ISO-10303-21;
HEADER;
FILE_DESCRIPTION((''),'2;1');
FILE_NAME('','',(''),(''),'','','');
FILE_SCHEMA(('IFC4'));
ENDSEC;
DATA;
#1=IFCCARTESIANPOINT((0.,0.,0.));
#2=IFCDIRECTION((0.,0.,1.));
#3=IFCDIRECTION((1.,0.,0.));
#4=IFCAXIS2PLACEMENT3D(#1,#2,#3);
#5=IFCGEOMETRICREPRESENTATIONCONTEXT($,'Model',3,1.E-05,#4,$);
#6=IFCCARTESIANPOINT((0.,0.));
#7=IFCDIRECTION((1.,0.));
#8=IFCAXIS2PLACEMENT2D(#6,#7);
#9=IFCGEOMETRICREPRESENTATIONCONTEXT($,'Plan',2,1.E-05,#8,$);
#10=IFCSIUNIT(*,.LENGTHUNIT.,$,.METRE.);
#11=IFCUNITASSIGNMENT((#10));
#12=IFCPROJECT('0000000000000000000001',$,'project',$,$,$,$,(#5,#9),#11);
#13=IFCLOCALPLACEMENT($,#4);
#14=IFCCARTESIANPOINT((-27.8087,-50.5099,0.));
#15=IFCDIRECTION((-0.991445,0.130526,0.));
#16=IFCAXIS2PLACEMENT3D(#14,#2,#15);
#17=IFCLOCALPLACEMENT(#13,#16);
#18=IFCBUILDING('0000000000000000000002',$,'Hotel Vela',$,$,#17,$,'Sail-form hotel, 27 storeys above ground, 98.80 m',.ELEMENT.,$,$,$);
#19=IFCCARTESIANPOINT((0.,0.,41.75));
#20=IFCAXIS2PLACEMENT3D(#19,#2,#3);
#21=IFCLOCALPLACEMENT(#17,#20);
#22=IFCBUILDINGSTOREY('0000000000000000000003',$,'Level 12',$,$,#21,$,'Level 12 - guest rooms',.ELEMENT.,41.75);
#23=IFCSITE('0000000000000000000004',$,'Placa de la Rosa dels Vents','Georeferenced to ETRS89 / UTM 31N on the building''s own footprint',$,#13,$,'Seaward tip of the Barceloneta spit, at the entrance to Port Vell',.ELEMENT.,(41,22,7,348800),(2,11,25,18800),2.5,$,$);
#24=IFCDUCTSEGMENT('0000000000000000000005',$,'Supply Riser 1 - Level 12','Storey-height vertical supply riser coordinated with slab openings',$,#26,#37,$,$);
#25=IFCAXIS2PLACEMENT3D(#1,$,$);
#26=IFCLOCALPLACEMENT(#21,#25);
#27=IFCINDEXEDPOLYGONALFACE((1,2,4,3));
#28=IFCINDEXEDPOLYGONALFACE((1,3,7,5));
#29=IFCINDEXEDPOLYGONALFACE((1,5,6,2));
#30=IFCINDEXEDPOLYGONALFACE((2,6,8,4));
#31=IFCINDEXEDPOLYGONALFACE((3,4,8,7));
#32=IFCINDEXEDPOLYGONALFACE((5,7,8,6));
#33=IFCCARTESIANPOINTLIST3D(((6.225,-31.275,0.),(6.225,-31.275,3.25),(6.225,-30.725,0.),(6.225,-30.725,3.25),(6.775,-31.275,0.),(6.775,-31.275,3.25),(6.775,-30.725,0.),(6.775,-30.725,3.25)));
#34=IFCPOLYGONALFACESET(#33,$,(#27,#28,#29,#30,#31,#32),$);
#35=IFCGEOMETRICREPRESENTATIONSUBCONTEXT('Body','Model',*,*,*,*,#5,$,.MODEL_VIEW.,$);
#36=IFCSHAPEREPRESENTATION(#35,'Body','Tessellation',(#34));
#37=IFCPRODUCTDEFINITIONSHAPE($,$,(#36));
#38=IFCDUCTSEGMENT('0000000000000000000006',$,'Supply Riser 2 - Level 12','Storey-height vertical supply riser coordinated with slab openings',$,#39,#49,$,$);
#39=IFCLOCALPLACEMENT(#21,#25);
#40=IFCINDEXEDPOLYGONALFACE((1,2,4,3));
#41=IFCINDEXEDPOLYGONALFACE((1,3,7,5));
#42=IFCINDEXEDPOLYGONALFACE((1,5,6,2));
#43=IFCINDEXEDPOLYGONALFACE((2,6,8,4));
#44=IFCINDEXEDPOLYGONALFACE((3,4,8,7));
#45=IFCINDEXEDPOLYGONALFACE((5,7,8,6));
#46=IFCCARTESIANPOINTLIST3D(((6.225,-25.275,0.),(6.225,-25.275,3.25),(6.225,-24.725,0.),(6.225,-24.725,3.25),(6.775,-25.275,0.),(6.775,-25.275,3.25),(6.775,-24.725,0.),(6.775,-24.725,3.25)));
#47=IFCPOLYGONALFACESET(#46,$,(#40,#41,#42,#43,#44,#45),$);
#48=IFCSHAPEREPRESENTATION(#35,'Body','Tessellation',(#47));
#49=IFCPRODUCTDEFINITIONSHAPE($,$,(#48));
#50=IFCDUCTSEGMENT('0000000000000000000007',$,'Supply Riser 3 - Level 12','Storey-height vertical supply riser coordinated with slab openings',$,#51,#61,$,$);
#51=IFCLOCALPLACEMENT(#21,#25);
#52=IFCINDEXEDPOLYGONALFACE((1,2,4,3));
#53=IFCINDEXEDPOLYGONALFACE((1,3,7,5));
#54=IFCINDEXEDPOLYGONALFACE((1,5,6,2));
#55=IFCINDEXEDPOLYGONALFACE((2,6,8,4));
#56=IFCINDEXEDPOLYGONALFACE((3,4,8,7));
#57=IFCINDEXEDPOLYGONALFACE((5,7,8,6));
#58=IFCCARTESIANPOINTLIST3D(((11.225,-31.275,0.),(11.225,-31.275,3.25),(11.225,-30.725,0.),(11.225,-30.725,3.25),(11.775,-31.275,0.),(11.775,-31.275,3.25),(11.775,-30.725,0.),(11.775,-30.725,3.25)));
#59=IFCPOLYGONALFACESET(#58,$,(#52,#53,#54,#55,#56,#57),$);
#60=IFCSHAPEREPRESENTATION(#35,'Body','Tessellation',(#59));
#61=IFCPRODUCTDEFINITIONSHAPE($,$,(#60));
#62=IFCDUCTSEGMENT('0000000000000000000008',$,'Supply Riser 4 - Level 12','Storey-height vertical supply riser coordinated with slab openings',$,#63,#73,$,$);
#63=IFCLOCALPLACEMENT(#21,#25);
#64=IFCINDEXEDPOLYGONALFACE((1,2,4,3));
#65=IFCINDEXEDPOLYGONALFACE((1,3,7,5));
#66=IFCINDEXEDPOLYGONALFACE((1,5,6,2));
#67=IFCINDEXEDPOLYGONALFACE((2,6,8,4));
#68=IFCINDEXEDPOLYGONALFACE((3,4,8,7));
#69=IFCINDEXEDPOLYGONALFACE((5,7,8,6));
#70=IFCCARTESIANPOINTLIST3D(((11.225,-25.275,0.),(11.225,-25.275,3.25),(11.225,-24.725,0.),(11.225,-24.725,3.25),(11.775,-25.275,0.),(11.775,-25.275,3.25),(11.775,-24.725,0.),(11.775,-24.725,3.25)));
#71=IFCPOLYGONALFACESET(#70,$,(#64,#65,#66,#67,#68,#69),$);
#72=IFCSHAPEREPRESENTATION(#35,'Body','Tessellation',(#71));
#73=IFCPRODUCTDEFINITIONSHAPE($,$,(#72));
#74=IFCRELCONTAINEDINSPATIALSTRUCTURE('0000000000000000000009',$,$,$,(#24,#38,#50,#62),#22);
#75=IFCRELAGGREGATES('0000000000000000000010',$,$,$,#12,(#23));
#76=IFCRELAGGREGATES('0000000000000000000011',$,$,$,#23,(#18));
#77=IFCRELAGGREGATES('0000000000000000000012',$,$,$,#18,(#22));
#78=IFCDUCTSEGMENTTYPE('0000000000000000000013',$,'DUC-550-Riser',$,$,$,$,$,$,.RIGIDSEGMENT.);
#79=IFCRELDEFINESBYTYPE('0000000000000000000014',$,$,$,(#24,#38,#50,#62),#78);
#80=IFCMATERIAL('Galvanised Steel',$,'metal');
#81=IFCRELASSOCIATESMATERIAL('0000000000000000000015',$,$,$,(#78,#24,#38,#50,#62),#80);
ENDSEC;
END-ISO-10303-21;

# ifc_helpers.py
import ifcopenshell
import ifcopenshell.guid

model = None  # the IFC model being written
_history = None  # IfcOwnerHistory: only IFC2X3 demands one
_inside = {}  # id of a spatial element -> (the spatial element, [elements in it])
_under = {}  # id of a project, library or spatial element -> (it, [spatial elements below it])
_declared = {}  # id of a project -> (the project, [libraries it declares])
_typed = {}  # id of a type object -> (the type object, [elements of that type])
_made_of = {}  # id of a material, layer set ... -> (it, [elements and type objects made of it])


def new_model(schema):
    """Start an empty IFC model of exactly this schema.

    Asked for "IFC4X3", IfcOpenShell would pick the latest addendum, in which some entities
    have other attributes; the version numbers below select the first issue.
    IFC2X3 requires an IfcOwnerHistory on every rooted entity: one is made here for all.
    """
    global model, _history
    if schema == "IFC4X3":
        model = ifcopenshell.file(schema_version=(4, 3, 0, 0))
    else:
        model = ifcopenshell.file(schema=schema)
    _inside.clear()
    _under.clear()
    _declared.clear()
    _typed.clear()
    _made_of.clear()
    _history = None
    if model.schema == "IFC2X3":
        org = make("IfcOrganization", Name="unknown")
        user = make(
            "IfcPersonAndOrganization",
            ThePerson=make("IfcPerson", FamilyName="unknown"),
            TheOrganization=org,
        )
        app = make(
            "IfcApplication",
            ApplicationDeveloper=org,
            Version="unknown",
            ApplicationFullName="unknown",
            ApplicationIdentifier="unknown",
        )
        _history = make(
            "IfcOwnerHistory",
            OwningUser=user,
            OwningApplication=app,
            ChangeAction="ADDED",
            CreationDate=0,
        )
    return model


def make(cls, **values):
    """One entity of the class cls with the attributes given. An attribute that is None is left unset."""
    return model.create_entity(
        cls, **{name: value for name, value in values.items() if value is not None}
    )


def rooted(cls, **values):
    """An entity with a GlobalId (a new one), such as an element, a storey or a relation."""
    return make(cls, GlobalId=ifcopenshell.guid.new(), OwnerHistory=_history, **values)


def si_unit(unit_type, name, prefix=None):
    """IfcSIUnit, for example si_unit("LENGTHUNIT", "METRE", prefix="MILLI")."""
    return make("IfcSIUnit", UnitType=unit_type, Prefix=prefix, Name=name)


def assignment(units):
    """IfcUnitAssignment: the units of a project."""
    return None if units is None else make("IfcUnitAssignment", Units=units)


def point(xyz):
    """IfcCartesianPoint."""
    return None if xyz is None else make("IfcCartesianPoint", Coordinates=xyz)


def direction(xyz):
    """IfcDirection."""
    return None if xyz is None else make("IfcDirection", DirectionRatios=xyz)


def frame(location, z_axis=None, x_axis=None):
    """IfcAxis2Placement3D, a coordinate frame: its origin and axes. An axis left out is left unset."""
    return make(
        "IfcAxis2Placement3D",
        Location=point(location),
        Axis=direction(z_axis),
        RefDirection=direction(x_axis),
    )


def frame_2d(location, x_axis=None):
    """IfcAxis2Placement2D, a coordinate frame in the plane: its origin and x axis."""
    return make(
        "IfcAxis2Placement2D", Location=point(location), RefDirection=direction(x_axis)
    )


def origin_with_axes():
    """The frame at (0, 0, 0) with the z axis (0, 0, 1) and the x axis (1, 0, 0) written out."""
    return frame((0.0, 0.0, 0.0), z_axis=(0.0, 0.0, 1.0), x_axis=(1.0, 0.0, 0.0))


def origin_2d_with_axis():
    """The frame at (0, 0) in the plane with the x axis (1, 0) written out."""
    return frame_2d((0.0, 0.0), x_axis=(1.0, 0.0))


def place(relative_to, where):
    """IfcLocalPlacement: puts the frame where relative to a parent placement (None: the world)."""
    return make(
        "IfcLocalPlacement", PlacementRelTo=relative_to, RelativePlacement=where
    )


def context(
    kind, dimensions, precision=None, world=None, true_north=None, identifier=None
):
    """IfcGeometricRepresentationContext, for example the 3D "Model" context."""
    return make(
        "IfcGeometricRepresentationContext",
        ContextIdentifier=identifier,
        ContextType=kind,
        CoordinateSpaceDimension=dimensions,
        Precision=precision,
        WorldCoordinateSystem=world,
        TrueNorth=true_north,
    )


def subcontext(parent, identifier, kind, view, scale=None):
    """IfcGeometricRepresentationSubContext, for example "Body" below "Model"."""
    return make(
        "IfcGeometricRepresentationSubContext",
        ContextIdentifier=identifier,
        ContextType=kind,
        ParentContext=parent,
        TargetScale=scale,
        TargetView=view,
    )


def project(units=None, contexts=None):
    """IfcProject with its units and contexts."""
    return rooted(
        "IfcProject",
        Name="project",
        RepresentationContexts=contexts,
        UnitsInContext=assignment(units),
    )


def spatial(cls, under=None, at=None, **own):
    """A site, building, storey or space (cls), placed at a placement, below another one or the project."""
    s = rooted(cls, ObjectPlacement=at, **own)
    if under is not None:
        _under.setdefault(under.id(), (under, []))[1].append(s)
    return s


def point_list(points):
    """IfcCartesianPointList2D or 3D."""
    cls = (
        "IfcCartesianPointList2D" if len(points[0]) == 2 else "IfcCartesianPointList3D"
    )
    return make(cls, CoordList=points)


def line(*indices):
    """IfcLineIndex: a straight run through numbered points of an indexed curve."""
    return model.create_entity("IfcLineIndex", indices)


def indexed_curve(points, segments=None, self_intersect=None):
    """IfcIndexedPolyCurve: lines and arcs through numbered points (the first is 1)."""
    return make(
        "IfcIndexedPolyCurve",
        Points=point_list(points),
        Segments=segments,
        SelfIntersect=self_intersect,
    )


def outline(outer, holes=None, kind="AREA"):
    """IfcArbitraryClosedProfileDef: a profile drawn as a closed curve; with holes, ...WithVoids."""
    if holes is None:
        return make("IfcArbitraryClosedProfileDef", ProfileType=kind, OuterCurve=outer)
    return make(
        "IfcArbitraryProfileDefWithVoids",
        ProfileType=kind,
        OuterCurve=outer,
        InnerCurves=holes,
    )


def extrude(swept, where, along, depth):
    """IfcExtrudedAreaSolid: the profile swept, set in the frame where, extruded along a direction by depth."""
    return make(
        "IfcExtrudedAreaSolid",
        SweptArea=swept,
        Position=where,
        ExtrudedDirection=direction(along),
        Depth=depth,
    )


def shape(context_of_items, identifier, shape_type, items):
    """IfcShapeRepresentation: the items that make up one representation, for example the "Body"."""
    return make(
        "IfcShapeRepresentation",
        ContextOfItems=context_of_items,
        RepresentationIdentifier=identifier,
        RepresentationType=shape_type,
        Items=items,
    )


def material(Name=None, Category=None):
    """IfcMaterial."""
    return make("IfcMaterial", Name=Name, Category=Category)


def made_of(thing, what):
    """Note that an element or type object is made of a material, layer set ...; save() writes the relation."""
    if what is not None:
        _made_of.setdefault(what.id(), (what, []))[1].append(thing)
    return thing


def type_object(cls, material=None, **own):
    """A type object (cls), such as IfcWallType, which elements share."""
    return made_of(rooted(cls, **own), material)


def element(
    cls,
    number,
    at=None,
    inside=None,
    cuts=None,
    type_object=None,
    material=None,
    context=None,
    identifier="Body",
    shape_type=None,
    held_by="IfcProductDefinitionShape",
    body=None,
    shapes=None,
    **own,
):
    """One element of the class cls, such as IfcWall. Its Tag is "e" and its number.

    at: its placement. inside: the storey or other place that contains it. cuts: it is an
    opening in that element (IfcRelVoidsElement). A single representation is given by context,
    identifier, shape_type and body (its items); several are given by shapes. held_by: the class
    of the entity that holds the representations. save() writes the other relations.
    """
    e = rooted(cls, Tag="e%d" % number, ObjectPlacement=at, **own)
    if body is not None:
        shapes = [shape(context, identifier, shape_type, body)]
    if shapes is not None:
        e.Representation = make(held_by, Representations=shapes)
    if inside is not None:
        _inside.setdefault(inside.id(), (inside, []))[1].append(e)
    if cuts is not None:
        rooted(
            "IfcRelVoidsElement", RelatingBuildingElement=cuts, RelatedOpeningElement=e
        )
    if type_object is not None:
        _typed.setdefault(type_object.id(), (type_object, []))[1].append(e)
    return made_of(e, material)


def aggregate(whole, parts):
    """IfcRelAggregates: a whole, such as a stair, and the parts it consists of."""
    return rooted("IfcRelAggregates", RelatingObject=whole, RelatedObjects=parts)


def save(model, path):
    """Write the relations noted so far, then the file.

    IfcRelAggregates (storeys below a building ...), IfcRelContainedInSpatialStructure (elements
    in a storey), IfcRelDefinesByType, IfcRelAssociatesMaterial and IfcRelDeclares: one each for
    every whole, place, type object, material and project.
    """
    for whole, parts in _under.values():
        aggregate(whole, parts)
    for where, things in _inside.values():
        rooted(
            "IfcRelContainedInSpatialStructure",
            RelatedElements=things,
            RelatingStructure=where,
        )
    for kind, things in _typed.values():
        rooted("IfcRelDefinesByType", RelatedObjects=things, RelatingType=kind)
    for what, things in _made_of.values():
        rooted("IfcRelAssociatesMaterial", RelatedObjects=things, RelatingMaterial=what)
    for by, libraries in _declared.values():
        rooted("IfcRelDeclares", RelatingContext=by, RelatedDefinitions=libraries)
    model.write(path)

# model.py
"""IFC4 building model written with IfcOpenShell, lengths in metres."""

from ifc_helpers import new_model, si_unit, frame, origin_with_axes, origin_2d_with_axis, place, context, subcontext, project, spatial, line, indexed_curve, outline, extrude, material, type_object, element, save


model = new_model("IFC4")

# Units and contexts
model_context = context("Model", 3, precision=1e-05, world=origin_with_axes())
plan_context = context("Plan", 2, precision=1e-05, world=origin_2d_with_axis())
body_context = subcontext(model_context, "Body", "Model", "MODEL_VIEW")
ifc_project = project(units=[si_unit("LENGTHUNIT", "METRE")], contexts=[model_context, plan_context])

# Site, building, storey
site_placement = place(None, origin_with_axes())
site = spatial("IfcSite", under=ifc_project, at=site_placement, Name="Placa de la Rosa dels Vents", Description="Georeferenced to ETRS89 / UTM 31N on the building's own footprint", LongName="Seaward tip of the Barceloneta spit, at the entrance to Port Vell", CompositionType="ELEMENT", RefLatitude=(41, 22, 7, 348800), RefLongitude=(2, 11, 25, 18800), RefElevation=2.5)
building_placement = place(site_placement, frame((-27.8087, -50.5099, 0.0), z_axis=(0.0, 0.0, 1.0), x_axis=(-0.991445, 0.130526, 0.0)))
building = spatial("IfcBuilding", under=site, at=building_placement, Name="Hotel Vela", LongName="Sail-form hotel, 27 storeys above ground, 98.80 m", CompositionType="ELEMENT")
storey_placement = place(building_placement, frame((0.0, 0.0, 41.75), z_axis=(0.0, 0.0, 1.0), x_axis=(1.0, 0.0, 0.0)))
storey = spatial("IfcBuildingStorey", under=building, at=storey_placement, Name="Level 12", LongName="Level 12 - guest rooms", CompositionType="ELEMENT", Elevation=41.75)

# Duct segments
ifc_material = material(Name="Galvanised Steel", Category="metal")
duct_segment_type = type_object("IfcDuctSegmentType", Name="DUC-550-Riser", PredefinedType="RIGIDSEGMENT", material=ifc_material)
for number, where, z_axis, x_axis, name in (
    (1, (6.225, -31.275, 0.0), (0.0, 0.0, 1.0), (1.0, 0.0, 0.0), "Supply Riser 1 - Level 12"),
    (2, (6.225, -25.275, 0.0), (0.0, 0.0, 1.0), (1.0, 0.0, 0.0), "Supply Riser 2 - Level 12"),
    (3, (11.225, -31.275, 0.0), (0.0, 0.0, 1.0), (1.0, 0.0, 0.0), "Supply Riser 3 - Level 12"),
    (4, (11.225, -25.275, 0.0), (0.0, 0.0, 1.0), (1.0, 0.0, 0.0), "Supply Riser 4 - Level 12"),
):
    element("IfcDuctSegment", number, at=place(storey_placement, frame(where, z_axis=z_axis, x_axis=x_axis)), inside=storey, type_object=duct_segment_type, material=ifc_material, Name=name, Description="Storey-height vertical supply riser coordinated with slab openings", context=body_context, shape_type="SweptSolid", body=[
        extrude(outline(indexed_curve([(0.0, 0.0), (0.55, 0.0), (0.55, 0.55), (0.0, 0.55)], segments=[line(1, 2, 3, 4, 1)])), origin_with_axes(), (0.0, 0.0, 1.0), 3.25),
    ])

save(model, "model.ifc")
